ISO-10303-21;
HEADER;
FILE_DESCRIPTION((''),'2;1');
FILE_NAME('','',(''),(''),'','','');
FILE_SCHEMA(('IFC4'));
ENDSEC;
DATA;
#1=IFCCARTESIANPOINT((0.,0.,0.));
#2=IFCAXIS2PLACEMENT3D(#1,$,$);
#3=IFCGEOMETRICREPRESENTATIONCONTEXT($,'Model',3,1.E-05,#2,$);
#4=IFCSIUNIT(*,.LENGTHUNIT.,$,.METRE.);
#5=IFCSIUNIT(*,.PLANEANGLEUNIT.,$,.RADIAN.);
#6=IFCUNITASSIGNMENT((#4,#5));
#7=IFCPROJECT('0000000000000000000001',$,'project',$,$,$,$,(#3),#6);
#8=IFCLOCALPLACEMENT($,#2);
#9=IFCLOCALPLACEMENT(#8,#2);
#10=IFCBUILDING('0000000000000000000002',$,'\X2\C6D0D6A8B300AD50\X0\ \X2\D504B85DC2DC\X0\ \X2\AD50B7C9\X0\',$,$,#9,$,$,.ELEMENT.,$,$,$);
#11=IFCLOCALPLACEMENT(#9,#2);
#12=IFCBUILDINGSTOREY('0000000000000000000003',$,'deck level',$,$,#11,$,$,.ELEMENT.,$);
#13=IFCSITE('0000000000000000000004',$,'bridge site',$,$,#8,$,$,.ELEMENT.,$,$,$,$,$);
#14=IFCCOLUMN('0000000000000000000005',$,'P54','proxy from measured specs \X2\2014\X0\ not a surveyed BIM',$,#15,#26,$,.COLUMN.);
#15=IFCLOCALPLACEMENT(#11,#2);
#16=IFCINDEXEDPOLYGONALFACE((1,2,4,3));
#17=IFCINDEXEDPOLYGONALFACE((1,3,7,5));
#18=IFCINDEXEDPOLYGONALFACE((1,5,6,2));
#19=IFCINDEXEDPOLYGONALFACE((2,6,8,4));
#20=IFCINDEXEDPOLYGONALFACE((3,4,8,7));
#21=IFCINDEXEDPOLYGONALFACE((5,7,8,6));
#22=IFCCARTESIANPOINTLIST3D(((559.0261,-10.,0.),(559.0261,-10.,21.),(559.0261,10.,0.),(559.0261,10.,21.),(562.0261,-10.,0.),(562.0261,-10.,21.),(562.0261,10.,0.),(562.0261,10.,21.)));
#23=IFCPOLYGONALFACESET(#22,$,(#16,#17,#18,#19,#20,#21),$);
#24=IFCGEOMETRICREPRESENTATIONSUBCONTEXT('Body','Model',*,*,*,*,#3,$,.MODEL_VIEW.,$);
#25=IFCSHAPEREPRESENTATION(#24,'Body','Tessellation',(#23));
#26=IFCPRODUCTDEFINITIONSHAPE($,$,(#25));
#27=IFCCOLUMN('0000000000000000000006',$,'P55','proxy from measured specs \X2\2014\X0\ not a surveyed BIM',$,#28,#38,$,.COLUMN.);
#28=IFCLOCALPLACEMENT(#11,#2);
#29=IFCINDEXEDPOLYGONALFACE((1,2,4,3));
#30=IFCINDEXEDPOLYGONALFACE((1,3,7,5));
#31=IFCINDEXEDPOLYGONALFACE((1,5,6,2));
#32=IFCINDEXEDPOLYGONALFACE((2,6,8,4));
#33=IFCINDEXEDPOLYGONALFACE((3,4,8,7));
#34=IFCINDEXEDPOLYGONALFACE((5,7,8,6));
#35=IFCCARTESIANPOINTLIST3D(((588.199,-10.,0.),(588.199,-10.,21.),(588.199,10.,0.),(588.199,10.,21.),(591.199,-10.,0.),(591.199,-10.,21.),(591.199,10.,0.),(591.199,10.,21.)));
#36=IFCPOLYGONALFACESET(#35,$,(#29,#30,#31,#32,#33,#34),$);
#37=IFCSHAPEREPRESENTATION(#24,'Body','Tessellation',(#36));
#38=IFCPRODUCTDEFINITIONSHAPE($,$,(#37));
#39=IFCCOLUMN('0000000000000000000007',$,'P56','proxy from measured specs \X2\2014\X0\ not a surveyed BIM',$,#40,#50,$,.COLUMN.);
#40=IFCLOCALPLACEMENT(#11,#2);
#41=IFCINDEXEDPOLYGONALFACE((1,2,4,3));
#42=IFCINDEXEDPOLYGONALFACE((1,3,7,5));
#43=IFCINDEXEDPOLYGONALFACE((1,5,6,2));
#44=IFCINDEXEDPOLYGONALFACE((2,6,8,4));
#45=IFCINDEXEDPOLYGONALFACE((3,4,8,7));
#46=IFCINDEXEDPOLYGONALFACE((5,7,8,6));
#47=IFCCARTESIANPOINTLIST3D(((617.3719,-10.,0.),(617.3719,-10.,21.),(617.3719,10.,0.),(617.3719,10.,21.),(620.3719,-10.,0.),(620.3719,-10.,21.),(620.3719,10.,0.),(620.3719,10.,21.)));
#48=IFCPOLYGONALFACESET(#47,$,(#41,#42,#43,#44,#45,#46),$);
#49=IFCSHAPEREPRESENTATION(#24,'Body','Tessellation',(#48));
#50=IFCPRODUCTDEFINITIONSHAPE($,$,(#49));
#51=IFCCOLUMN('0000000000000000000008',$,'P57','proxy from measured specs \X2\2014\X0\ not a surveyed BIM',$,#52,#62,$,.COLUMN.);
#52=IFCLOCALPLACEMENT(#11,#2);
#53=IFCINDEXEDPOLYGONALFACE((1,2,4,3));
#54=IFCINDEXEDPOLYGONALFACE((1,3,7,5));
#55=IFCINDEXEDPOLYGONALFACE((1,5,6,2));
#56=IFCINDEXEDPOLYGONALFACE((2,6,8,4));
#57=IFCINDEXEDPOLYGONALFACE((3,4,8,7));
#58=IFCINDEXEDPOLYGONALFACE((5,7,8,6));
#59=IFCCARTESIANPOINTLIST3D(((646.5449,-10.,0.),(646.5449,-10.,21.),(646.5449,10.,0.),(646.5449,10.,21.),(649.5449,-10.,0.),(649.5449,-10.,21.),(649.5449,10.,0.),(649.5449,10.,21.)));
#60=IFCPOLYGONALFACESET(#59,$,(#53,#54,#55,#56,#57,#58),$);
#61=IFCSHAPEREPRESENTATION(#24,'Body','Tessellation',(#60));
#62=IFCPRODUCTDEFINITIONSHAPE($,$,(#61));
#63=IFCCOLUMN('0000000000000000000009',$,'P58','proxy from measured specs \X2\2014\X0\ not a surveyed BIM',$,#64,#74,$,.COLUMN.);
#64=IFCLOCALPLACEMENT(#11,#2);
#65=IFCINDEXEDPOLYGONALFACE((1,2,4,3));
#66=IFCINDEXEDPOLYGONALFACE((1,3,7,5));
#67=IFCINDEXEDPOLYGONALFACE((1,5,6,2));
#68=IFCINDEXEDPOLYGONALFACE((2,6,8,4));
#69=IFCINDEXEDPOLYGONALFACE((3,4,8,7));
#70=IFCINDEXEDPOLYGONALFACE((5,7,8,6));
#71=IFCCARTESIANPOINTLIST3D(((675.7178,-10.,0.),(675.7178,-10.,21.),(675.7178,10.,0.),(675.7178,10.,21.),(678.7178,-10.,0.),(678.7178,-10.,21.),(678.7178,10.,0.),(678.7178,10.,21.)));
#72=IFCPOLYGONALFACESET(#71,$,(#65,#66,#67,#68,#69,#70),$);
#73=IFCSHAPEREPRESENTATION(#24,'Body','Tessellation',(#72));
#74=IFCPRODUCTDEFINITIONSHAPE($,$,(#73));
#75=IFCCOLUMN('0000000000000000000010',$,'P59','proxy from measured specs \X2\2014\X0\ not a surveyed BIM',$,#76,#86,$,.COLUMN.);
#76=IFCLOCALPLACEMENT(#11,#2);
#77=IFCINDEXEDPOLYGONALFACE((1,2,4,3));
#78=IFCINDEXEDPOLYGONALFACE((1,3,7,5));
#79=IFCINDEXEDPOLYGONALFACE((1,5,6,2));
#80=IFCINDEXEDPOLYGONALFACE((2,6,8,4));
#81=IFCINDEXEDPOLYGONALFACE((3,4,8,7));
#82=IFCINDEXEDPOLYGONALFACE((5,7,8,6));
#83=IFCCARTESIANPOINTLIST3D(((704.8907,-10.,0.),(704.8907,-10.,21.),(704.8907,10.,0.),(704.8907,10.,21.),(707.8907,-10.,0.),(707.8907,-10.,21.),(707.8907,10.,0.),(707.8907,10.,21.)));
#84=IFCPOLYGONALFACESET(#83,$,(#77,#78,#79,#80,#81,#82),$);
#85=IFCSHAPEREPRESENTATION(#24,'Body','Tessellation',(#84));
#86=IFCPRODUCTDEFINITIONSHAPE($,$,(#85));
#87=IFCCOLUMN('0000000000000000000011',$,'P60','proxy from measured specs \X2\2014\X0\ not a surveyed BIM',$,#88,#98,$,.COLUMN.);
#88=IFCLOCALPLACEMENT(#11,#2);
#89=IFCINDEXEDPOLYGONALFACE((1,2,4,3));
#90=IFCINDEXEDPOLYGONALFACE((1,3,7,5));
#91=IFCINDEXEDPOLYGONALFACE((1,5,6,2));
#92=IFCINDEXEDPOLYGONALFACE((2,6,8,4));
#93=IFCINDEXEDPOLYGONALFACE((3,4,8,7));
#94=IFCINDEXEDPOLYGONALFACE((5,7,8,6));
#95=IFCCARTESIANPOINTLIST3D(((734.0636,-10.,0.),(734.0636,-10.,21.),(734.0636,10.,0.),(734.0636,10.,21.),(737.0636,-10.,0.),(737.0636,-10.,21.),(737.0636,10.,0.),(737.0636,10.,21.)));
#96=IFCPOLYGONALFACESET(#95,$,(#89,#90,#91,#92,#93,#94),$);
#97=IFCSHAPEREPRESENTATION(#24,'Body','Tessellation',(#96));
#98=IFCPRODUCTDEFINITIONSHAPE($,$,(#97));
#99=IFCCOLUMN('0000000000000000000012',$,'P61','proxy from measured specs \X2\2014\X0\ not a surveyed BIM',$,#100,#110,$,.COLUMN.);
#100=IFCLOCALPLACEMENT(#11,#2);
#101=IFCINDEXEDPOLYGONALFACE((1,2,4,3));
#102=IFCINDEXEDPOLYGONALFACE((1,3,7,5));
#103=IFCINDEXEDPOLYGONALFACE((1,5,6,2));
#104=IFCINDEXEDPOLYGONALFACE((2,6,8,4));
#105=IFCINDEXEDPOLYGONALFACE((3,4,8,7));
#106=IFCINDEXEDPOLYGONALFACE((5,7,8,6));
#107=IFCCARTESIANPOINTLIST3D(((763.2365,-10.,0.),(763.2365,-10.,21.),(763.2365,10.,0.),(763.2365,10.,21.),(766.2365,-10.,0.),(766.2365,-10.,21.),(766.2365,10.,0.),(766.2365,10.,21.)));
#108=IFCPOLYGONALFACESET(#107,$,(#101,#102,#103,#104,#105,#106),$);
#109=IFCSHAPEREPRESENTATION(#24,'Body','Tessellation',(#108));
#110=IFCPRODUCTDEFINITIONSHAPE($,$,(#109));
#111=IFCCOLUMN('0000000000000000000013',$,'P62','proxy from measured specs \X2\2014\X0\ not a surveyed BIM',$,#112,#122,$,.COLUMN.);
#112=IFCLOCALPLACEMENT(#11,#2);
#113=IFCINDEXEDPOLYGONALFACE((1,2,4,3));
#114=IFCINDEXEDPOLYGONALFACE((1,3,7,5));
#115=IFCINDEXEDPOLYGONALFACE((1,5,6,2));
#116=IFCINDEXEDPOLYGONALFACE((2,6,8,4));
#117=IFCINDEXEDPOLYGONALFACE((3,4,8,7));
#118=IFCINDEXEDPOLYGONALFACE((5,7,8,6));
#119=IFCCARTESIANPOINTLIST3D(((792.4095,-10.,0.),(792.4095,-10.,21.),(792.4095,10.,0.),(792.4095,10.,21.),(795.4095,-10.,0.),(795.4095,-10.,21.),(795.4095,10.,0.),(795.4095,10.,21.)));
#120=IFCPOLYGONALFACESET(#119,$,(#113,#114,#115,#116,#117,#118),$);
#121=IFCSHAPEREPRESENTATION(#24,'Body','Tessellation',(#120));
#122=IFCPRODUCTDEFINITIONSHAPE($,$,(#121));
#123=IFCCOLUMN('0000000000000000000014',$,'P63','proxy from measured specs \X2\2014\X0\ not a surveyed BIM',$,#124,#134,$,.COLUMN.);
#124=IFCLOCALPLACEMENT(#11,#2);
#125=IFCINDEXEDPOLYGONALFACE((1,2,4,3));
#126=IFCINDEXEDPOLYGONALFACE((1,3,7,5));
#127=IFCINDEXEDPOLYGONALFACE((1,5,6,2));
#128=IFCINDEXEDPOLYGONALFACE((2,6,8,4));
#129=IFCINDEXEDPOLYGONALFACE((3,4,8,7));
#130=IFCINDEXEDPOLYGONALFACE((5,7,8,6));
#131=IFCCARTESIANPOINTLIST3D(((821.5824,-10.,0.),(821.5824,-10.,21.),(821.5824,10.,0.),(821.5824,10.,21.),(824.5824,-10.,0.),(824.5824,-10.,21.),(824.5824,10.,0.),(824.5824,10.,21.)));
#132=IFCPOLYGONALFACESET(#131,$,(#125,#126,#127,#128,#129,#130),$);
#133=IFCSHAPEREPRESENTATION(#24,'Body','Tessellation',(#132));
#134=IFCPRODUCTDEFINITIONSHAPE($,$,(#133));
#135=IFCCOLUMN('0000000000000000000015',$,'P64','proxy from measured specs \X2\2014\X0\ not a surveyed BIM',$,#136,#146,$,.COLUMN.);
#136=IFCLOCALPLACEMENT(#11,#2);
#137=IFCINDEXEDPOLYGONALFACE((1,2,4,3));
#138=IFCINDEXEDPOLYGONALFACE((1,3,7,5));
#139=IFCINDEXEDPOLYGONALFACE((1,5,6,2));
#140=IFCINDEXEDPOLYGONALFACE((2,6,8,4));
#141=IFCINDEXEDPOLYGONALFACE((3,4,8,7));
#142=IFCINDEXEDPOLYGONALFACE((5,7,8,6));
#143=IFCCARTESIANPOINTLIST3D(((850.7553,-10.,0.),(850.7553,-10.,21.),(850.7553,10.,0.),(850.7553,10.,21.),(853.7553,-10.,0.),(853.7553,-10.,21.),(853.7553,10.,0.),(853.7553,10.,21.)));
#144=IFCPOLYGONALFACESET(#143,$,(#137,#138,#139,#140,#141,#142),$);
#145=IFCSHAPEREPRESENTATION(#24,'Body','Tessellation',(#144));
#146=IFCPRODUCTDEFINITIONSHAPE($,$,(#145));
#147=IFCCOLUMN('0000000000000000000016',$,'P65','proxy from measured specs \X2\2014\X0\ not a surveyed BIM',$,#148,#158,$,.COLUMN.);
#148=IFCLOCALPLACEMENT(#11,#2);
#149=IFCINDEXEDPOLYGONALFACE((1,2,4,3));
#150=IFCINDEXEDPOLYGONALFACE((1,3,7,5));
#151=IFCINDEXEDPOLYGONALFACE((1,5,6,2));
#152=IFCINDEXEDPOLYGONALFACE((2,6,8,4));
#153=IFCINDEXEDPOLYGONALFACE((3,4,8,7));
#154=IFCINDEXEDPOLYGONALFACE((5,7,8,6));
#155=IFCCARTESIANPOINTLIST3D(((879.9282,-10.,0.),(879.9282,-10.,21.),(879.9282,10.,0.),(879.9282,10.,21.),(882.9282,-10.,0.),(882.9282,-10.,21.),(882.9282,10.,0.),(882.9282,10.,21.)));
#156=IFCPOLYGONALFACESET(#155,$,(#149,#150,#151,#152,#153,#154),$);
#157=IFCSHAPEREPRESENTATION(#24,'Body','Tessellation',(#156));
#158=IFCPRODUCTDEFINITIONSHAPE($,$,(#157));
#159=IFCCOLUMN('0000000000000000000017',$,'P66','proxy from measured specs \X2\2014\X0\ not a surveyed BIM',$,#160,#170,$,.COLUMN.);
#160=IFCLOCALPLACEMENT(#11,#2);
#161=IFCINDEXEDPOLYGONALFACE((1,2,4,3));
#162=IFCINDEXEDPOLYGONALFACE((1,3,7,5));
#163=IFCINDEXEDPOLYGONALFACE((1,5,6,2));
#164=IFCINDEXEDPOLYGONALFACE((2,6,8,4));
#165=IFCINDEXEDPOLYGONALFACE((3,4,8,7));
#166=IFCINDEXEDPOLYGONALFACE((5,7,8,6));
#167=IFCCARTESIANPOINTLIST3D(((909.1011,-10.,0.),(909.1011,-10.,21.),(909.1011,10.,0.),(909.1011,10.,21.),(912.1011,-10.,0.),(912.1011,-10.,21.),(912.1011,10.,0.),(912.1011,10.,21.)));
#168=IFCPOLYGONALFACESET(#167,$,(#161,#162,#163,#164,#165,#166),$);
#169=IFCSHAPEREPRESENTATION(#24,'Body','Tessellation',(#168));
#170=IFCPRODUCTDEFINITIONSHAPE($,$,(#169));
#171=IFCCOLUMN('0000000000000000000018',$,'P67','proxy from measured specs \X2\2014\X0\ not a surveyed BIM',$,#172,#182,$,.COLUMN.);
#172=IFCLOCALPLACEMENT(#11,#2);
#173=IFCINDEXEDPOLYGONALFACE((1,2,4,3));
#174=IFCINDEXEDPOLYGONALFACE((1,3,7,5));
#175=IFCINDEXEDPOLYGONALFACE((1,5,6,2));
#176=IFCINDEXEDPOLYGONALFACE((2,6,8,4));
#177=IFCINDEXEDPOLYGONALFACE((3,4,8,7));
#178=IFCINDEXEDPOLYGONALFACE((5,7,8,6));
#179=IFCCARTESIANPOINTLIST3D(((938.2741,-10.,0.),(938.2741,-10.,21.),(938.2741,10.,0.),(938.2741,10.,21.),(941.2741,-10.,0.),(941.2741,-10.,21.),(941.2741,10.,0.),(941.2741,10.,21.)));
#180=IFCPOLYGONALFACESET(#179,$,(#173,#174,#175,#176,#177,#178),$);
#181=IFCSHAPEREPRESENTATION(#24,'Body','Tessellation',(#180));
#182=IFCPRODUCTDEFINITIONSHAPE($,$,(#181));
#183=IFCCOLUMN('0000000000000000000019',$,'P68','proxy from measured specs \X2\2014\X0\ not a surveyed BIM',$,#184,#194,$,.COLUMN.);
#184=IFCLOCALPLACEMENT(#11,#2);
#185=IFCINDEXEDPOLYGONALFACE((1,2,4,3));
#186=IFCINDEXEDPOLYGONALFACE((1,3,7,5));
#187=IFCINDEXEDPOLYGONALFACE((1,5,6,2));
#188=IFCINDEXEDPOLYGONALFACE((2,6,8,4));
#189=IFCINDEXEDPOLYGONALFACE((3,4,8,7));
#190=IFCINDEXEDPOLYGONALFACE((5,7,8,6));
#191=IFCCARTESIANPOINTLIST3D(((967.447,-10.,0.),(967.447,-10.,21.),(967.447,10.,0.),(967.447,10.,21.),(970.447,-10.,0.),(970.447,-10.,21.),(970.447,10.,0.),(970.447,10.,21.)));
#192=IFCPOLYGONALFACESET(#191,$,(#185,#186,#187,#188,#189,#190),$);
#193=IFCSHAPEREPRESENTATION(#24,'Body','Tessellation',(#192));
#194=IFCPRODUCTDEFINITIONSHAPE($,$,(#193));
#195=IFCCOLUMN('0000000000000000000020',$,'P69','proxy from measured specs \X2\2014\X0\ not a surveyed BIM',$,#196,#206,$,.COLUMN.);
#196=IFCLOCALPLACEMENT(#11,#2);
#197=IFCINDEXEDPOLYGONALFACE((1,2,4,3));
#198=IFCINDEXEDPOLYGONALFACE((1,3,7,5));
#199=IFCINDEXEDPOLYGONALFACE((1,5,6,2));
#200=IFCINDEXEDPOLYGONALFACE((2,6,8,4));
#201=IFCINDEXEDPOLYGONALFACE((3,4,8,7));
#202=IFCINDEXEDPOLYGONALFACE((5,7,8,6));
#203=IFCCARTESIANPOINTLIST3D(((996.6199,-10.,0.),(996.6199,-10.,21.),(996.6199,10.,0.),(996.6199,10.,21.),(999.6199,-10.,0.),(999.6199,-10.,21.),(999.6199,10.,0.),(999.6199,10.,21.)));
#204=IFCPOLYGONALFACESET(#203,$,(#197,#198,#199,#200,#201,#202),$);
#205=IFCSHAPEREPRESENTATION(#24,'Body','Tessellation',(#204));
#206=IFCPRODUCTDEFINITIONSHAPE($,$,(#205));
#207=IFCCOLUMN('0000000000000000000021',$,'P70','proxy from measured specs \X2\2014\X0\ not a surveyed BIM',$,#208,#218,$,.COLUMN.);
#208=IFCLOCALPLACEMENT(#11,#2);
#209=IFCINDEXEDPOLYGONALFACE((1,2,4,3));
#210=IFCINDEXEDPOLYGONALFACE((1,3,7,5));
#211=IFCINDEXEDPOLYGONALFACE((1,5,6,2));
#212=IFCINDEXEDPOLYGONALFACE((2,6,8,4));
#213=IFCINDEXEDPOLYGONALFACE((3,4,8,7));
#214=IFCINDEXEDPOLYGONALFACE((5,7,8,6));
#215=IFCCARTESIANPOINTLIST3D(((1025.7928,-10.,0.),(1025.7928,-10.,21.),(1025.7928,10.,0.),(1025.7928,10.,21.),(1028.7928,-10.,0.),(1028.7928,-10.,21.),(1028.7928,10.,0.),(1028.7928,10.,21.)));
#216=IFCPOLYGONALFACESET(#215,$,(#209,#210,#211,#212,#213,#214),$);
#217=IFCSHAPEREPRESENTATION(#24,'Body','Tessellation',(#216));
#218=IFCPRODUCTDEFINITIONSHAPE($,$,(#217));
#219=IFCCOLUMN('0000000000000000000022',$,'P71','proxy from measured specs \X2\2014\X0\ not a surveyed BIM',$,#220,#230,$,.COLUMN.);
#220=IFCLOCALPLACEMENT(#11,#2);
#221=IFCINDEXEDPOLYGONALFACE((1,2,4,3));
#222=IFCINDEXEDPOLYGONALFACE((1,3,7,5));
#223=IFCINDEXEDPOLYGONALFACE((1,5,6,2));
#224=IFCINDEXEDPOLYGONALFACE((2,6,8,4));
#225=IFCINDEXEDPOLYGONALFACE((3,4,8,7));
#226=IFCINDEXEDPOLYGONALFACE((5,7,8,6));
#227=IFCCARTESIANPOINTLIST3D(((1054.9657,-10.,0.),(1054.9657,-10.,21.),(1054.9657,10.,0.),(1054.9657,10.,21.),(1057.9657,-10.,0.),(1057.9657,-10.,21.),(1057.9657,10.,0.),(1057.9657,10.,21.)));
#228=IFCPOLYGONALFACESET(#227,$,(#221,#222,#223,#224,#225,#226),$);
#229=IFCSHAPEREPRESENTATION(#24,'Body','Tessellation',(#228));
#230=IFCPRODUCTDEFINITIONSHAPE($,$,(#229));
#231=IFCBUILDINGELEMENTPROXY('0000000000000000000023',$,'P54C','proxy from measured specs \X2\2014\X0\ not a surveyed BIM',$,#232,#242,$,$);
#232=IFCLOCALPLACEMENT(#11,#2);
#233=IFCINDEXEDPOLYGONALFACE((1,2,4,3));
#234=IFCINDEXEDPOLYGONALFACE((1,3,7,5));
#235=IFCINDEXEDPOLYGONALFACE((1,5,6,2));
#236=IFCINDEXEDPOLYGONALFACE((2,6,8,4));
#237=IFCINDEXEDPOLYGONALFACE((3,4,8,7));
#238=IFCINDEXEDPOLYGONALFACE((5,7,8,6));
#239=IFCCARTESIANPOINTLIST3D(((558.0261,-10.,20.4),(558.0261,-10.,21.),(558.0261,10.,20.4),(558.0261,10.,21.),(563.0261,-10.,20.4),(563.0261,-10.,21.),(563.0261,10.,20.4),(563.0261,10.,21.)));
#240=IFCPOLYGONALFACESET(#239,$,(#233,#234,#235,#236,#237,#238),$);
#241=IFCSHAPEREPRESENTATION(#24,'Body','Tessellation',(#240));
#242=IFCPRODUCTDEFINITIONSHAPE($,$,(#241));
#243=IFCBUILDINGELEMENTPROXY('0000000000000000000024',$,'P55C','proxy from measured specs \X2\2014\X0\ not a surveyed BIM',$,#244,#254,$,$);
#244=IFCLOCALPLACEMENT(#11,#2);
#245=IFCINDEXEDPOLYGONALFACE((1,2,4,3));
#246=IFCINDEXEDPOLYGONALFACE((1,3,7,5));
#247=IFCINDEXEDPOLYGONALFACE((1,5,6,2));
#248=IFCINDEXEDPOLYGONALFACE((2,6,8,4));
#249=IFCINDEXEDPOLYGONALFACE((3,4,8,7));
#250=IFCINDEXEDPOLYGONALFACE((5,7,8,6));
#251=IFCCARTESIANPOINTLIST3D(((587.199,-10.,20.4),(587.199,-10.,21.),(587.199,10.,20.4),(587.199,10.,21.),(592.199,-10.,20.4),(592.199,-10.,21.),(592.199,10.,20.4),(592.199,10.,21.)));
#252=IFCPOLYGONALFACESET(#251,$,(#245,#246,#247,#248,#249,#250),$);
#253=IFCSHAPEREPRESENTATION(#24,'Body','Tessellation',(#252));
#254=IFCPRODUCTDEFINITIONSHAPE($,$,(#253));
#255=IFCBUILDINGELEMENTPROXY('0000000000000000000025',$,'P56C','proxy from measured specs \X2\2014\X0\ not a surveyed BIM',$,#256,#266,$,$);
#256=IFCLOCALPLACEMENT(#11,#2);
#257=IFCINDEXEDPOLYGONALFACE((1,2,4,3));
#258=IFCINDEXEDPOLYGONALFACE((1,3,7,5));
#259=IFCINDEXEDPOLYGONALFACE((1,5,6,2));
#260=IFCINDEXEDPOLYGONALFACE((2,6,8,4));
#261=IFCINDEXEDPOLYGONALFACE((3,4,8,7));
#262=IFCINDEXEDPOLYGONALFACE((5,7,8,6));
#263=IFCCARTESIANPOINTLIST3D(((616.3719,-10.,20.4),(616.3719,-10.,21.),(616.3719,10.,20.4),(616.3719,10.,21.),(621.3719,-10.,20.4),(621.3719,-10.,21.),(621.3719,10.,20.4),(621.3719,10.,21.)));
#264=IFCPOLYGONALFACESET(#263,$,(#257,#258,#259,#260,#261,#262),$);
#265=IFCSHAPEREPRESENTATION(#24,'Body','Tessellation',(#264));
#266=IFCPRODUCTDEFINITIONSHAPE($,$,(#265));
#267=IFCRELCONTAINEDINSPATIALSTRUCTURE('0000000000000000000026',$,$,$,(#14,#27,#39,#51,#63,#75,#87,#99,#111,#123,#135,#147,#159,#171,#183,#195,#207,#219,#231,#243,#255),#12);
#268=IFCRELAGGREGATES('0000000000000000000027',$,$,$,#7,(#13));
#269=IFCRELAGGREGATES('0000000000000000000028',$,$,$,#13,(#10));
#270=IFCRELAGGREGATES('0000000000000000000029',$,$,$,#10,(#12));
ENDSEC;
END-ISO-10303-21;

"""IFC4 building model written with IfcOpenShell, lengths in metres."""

from ifc_helpers import new_model, si_unit, frame, origin, origin_2d, place, context, subcontext, project, spatial, rectangle, extrude, element, save


model = new_model("IFC4")

# Units and contexts
model_context = context("Model", 3, precision=1e-05, world=origin())
body_context = subcontext(model_context, "Body", "Model", "MODEL_VIEW")
ifc_project = project(units=[si_unit("LENGTHUNIT", "METRE"), si_unit("PLANEANGLEUNIT", "RADIAN")], contexts=[model_context])

# Site, building, storey
site_placement = place(None, origin())
site = spatial("IfcSite", under=ifc_project, at=site_placement, Name="bridge site", CompositionType="ELEMENT")
building_placement = place(site_placement, origin())
building = spatial("IfcBuilding", under=site, at=building_placement, Name="원효대교 프록시 교량", CompositionType="ELEMENT")
storey_placement = place(building_placement, origin())
storey = spatial("IfcBuildingStorey", under=building, at=storey_placement, Name="deck level", CompositionType="ELEMENT")

# Columns
for number, where, name in (
    (1, (560.5261, 0.0, 0.0), "P54"),
    (2, (589.699, 0.0, 0.0), "P55"),
    (3, (618.8719, 0.0, 0.0), "P56"),
    (4, (648.0449, 0.0, 0.0), "P57"),
    (5, (677.2178, 0.0, 0.0), "P58"),
    (6, (706.3907, 0.0, 0.0), "P59"),
    (7, (735.5636, 0.0, 0.0), "P60"),
    (8, (764.7365, 0.0, 0.0), "P61"),
    (9, (793.9095, 0.0, 0.0), "P62"),
    (10, (823.0824, 0.0, 0.0), "P63"),
    (11, (852.2553, 0.0, 0.0), "P64"),
    (12, (881.4282, 0.0, 0.0), "P65"),
    (13, (910.6011, 0.0, 0.0), "P66"),
    (14, (939.7741, 0.0, 0.0), "P67"),
    (15, (968.947, 0.0, 0.0), "P68"),
    (16, (998.1199, 0.0, 0.0), "P69"),
    (17, (1027.2928, 0.0, 0.0), "P70"),
    (18, (1056.4657, 0.0, 0.0), "P71"),
):
    element("IfcColumn", number, at=place(storey_placement, frame(where)), inside=storey, Name=name, Description="proxy from measured specs — not a surveyed BIM", PredefinedType="COLUMN", context=body_context, shape_type="SweptSolid", body=[
        extrude(rectangle(XDim=3.0, YDim=20.0, at=origin_2d()), origin(), (0.0, 0.0, 1.0), 21.0),
    ])

# Building element proxies
for number, where, name in (
    (19, (560.5261, 0.0, 20.4), "P54C"),
    (20, (589.699, 0.0, 20.4), "P55C"),
    (21, (618.8719, 0.0, 20.4), "P56C"),
):
    element("IfcBuildingElementProxy", number, at=place(storey_placement, frame(where)), inside=storey, Name=name, Description="proxy from measured specs — not a surveyed BIM", context=body_context, shape_type="SweptSolid", body=[
        extrude(rectangle(XDim=5.0, YDim=20.0, at=origin_2d()), origin(), (0.0, 0.0, 1.0), 0.6),
    ])

save(model, "model.ifc")
